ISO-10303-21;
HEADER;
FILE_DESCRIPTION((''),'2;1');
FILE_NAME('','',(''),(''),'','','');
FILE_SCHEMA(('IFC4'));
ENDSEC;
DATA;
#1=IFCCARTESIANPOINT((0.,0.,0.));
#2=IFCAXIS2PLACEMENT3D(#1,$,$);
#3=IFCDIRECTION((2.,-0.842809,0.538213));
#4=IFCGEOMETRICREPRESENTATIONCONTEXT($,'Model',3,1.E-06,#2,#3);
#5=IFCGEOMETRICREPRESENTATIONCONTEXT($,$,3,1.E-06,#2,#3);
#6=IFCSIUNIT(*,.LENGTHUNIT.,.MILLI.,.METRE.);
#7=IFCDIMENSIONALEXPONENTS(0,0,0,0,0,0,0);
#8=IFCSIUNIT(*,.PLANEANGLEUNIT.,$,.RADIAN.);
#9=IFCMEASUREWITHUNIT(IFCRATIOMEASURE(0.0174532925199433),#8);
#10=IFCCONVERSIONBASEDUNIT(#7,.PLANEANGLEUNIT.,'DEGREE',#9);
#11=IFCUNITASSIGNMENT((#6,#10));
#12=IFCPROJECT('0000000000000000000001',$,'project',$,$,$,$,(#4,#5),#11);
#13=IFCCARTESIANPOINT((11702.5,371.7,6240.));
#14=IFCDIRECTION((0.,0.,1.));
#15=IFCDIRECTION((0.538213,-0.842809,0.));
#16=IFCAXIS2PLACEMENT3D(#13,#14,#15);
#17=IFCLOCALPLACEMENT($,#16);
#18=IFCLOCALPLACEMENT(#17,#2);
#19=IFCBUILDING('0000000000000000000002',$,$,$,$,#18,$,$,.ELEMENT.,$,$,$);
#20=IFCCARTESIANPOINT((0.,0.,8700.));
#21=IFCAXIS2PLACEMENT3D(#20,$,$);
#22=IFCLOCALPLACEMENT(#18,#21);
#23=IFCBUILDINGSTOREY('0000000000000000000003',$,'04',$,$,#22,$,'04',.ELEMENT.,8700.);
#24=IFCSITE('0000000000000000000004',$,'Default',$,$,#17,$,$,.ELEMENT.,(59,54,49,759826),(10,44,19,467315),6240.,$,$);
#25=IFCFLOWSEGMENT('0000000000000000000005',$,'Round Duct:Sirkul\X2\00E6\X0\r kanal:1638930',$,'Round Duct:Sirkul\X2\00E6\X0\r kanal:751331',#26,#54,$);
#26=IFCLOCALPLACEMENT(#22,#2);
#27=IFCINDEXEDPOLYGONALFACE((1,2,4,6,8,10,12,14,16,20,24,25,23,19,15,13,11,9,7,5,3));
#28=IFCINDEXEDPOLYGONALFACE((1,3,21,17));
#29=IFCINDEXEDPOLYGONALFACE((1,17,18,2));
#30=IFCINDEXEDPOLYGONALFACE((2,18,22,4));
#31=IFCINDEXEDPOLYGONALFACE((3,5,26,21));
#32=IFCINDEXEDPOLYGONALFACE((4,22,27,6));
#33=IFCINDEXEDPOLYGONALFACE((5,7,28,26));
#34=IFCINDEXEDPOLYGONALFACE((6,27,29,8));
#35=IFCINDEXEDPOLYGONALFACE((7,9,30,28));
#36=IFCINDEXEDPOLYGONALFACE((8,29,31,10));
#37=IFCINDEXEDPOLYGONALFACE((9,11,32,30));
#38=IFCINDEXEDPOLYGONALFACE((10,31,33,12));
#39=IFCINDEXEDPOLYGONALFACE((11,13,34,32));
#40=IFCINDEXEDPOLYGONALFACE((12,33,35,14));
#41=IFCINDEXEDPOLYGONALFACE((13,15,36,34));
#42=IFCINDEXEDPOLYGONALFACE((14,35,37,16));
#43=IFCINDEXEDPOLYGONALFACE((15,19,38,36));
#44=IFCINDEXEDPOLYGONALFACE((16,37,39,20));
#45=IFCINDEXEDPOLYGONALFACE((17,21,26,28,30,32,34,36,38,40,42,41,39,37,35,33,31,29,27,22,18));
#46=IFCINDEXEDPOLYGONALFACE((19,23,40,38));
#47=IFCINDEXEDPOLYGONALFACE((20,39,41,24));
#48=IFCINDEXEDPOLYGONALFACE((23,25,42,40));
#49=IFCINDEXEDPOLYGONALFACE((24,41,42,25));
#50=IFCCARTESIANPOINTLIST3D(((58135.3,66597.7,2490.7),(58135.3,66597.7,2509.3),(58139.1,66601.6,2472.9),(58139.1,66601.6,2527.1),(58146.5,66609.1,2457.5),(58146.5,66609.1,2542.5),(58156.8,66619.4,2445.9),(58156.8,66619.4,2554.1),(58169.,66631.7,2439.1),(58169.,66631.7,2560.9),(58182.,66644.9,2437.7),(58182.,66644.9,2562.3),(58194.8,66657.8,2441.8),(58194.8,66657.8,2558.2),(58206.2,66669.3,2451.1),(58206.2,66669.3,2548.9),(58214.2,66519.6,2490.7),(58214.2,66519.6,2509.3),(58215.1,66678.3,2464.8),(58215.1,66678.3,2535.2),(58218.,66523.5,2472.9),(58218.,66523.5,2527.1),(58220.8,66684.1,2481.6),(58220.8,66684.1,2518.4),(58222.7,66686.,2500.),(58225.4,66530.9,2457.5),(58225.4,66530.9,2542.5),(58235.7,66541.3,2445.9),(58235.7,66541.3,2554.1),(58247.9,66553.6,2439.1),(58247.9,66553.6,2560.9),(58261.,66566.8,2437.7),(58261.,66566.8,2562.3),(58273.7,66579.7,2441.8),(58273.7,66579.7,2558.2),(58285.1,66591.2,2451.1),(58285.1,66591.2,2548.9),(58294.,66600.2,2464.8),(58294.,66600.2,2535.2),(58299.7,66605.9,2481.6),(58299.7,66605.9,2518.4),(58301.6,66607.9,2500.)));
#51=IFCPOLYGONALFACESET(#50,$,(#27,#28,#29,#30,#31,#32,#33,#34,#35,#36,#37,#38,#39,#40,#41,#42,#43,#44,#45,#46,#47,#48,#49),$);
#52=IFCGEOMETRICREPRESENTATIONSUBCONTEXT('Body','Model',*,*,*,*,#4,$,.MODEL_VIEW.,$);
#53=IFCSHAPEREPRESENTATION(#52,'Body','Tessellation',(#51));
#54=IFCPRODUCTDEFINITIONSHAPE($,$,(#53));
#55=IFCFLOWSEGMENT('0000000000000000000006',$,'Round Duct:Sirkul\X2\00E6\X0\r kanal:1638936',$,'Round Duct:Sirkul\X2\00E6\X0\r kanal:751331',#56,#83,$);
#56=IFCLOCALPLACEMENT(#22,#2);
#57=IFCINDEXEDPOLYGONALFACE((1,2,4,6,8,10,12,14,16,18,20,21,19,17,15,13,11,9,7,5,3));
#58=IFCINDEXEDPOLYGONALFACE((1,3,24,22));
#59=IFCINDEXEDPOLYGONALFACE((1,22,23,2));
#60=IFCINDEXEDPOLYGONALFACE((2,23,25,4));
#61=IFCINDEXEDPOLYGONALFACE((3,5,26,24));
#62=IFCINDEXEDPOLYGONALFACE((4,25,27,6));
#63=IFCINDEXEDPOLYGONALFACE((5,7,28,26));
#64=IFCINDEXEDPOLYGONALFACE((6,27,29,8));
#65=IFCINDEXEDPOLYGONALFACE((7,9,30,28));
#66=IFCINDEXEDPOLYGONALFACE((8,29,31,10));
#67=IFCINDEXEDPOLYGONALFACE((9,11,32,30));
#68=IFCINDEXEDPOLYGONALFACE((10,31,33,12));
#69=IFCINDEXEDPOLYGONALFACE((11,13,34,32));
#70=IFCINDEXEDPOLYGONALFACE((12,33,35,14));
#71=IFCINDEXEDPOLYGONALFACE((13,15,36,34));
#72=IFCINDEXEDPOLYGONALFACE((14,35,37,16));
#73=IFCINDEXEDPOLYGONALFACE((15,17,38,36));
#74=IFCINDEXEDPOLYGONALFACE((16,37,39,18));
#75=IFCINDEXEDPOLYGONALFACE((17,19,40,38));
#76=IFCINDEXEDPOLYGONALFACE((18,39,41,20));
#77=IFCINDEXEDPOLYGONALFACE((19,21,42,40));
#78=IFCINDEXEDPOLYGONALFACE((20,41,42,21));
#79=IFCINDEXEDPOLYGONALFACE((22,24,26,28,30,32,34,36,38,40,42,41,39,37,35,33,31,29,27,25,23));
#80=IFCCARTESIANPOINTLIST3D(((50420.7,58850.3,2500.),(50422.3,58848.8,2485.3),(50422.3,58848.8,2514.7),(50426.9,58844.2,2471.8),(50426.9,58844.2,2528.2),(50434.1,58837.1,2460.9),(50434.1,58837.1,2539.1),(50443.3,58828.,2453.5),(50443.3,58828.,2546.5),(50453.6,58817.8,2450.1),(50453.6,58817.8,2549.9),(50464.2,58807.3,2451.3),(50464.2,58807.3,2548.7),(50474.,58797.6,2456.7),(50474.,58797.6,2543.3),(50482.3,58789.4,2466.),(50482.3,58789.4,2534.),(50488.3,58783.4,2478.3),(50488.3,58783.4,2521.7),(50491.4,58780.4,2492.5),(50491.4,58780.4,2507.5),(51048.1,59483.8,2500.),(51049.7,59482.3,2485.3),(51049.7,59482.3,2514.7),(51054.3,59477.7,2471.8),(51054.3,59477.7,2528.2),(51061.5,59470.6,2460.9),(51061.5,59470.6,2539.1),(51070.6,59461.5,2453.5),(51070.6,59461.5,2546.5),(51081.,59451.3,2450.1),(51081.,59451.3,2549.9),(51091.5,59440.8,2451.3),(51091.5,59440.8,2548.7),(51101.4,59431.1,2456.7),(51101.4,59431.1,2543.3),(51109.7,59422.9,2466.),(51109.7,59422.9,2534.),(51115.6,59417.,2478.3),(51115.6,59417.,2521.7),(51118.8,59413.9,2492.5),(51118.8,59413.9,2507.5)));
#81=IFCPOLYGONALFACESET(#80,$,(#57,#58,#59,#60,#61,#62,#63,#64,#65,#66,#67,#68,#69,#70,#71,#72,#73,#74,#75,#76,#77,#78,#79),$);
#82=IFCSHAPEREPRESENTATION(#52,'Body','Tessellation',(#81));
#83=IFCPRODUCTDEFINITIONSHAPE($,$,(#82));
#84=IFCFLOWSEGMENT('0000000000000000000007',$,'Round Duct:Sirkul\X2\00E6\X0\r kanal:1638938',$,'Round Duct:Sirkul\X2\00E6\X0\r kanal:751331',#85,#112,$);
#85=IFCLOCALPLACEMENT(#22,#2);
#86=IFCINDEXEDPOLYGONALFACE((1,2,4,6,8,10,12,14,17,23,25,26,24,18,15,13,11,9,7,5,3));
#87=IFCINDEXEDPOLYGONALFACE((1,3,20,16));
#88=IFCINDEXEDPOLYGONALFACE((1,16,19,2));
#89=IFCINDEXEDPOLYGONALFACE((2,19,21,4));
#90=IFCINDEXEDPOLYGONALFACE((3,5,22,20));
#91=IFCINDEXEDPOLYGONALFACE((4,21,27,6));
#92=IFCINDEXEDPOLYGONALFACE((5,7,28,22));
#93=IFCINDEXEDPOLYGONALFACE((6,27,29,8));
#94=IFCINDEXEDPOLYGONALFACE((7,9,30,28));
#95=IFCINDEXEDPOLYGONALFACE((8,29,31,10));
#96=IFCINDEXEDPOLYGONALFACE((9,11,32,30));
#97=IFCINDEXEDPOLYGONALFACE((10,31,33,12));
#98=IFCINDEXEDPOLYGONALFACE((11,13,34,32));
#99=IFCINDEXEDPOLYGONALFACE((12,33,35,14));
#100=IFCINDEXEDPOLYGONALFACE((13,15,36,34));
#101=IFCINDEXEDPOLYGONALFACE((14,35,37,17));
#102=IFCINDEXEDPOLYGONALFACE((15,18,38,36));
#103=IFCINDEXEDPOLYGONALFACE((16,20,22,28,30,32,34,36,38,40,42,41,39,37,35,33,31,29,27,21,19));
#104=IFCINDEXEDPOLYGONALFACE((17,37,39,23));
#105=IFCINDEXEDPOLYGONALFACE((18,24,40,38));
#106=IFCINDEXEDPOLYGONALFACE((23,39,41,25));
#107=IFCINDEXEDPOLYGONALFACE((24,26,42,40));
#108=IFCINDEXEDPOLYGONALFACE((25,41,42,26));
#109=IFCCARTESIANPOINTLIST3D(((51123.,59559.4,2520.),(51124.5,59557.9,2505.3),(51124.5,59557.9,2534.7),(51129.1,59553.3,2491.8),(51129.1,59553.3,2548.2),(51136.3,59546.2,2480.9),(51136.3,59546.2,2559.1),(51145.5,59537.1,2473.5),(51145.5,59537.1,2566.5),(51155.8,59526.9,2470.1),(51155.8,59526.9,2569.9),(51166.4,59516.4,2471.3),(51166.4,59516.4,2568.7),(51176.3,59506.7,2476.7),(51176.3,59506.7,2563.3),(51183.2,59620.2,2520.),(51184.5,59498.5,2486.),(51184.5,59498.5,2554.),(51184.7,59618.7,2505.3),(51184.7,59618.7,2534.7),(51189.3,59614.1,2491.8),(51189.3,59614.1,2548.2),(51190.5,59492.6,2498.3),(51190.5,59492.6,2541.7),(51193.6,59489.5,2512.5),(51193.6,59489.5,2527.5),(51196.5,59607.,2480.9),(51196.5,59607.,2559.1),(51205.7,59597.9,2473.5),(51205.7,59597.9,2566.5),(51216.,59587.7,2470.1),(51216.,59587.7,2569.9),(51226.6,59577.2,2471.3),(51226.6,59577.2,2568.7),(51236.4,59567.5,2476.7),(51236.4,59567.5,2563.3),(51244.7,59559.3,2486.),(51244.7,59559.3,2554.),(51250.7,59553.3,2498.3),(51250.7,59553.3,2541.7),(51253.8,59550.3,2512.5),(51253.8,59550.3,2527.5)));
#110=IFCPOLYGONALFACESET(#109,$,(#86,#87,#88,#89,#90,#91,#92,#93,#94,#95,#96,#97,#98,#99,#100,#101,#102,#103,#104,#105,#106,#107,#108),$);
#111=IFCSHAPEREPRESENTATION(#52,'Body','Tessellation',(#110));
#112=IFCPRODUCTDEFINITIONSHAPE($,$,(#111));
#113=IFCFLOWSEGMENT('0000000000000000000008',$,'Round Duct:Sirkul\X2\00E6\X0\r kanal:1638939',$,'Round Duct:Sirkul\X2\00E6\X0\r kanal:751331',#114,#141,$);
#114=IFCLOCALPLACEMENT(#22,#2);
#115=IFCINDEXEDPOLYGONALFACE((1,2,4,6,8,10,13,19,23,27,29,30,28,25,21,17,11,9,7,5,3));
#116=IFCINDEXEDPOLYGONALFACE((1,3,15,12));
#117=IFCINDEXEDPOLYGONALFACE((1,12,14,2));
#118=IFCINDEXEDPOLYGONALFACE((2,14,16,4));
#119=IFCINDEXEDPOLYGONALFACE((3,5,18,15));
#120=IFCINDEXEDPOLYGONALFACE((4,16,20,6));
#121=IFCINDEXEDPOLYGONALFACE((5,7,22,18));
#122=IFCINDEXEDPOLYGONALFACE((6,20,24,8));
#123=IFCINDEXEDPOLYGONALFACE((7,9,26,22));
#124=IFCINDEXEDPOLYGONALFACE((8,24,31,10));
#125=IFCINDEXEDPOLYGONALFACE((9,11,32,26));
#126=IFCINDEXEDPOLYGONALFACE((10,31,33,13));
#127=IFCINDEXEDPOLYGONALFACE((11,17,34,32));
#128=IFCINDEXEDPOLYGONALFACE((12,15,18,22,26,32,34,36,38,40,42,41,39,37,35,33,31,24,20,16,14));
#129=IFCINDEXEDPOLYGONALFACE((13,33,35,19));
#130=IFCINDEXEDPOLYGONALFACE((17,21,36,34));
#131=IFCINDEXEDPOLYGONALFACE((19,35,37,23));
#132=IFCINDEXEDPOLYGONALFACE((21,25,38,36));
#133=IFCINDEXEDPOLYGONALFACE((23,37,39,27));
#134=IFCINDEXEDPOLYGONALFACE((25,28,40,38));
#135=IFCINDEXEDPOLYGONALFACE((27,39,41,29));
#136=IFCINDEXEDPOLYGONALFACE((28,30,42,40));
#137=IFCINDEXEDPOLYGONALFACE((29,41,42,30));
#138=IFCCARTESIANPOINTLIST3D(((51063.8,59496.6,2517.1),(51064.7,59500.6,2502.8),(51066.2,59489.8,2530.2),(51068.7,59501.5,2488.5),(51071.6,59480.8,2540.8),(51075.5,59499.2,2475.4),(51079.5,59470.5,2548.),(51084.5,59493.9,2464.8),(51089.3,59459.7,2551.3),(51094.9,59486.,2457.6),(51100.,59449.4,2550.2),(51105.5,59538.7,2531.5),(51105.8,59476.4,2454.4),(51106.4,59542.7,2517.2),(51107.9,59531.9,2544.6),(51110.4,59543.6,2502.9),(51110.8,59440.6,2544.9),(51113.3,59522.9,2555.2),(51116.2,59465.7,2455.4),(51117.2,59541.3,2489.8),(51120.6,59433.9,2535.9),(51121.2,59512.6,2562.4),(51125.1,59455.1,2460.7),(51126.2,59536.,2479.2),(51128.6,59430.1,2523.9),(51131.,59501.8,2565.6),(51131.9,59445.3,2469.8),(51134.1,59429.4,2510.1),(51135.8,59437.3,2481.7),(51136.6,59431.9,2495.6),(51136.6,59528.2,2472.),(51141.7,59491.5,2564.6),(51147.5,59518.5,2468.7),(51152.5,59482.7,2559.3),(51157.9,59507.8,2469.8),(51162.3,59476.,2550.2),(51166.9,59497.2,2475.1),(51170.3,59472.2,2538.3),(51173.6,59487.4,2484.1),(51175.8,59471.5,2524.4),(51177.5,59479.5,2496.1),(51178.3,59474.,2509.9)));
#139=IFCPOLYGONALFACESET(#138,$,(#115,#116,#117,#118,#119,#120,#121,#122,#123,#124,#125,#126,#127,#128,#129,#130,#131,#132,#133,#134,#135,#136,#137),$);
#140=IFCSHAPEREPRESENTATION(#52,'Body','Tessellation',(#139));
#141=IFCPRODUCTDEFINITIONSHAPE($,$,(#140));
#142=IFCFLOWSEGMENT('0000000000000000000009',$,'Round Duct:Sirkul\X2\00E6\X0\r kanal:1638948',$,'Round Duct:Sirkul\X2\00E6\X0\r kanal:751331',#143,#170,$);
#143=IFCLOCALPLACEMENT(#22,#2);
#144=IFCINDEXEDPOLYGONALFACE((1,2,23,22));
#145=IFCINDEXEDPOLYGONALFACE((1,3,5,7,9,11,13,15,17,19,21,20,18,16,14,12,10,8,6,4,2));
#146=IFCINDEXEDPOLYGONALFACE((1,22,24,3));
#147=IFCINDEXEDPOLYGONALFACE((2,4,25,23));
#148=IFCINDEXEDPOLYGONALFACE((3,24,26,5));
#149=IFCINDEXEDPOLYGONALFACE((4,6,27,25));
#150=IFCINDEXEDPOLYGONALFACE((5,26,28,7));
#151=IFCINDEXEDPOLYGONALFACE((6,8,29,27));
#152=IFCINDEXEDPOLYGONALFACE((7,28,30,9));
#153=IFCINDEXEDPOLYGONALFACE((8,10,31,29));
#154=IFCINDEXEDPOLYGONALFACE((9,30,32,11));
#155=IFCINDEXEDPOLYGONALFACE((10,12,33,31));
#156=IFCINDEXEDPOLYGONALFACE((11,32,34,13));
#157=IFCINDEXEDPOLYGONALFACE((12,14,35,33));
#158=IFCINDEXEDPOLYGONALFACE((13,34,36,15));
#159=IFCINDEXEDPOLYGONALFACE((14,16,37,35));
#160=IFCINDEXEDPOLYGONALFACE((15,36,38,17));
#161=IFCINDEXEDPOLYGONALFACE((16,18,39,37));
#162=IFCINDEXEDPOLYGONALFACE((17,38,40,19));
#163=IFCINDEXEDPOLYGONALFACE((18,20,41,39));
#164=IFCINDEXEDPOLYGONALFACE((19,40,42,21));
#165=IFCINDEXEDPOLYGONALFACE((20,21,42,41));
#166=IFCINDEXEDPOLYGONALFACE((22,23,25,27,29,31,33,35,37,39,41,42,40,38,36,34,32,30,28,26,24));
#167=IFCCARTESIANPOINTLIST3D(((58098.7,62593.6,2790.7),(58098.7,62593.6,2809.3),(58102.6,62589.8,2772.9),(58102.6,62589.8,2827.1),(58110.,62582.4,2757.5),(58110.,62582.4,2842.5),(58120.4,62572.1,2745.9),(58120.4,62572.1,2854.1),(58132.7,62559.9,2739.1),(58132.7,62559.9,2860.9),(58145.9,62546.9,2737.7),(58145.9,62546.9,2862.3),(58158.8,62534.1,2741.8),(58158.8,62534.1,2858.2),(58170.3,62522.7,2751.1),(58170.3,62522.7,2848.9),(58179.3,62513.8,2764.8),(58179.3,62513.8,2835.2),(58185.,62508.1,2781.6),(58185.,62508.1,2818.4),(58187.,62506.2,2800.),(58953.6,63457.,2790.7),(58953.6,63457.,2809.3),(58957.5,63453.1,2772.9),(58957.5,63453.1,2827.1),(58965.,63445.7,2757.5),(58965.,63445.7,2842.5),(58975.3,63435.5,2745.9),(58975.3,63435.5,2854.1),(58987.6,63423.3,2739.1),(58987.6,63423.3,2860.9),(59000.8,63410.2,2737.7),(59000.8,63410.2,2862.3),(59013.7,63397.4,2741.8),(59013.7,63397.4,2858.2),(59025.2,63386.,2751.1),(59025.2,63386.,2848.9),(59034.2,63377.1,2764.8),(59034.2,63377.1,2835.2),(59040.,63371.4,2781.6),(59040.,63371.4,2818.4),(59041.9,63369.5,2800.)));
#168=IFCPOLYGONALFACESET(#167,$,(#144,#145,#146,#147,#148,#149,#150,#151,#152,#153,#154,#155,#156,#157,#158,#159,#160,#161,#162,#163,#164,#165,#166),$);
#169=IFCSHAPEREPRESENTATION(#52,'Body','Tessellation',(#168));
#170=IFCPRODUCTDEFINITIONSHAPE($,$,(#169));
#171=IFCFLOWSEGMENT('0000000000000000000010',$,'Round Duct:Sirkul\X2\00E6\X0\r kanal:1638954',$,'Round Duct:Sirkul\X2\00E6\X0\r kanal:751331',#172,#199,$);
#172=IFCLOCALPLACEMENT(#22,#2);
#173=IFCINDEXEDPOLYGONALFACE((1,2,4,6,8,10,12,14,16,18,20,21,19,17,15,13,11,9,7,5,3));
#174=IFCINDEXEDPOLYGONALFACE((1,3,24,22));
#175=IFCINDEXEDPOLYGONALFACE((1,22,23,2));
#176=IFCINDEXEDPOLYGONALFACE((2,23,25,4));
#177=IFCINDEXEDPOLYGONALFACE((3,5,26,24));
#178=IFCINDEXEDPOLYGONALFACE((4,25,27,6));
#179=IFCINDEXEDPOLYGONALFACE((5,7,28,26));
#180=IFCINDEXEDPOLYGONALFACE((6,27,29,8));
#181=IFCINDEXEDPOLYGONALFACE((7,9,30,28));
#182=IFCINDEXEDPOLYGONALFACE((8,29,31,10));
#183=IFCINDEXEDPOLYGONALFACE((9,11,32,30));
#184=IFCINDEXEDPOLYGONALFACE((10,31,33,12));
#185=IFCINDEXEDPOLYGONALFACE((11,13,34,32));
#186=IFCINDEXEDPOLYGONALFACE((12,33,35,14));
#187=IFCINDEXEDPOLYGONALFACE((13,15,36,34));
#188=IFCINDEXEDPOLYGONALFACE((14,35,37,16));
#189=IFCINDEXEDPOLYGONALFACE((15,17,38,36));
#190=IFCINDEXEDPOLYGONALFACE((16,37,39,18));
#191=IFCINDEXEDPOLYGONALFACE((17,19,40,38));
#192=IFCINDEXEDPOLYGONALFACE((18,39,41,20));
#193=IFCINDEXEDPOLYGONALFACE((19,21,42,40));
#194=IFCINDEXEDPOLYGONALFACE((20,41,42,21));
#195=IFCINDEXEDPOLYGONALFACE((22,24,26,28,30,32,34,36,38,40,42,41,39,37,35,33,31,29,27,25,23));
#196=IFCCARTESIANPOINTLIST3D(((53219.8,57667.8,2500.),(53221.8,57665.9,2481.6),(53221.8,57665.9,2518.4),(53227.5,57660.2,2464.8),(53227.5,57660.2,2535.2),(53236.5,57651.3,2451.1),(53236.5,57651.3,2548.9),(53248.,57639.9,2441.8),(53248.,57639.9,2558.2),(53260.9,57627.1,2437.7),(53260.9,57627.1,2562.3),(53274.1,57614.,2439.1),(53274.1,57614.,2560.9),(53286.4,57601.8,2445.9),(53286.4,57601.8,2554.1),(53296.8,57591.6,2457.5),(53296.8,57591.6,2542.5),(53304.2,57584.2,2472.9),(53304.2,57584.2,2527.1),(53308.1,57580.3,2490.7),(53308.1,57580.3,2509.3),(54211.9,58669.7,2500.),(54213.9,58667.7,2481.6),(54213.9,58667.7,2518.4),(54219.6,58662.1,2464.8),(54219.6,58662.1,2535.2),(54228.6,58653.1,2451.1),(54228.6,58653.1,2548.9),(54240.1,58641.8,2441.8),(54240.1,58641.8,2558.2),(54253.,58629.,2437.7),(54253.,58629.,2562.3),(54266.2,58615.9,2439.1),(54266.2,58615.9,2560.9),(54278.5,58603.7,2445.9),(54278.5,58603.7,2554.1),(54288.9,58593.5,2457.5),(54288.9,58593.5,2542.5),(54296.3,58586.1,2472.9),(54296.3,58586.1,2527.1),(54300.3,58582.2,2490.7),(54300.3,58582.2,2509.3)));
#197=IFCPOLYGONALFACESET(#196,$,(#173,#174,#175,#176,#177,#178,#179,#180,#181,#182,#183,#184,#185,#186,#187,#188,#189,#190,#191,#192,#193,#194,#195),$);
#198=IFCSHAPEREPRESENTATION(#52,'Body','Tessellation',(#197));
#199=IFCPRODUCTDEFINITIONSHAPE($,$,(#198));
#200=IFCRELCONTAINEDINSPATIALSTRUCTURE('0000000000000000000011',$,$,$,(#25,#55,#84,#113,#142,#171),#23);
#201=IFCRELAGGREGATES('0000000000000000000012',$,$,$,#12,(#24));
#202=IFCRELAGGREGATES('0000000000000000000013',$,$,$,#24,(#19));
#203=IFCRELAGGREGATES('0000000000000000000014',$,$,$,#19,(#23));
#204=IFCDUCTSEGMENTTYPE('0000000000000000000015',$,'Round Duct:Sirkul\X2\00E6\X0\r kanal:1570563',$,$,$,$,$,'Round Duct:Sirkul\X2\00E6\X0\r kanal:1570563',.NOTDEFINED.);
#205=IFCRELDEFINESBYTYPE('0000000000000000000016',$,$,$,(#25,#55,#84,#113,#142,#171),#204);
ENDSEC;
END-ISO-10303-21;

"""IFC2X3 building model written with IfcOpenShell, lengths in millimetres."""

from ifc_helpers import new_model, entity, si_unit, converted_unit, direction, frame, frame_2d, origin, origin_2d_with_axis, place, context, subcontext, project, spatial, circle, extrude, type_object, element, save


model = new_model("IFC2X3")

# Units and contexts
model_context = context("Model", 3, precision=1e-06, world=origin(), true_north=direction((2.0, -0.842809, 0.538213)))
context_of_model = context(None, 3, precision=1e-06, world=origin(), true_north=direction((2.0, -0.842809, 0.538213)))
body_context = subcontext(model_context, "Body", "Model", "MODEL_VIEW")
ifc_project = project(units=[si_unit("LENGTHUNIT", "METRE", prefix="MILLI"), converted_unit("PLANEANGLEUNIT", "DEGREE", entity("IfcRatioMeasure", 0.0174532925199433), si_unit("PLANEANGLEUNIT", "RADIAN"), dimensions=[0, 0, 0, 0, 0, 0, 0])], contexts=[model_context, context_of_model])

# Site, building, storey
site_placement = place(None, frame((11702.5, 371.7, 6240.0), z_axis=(0.0, 0.0, 1.0), x_axis=(0.538213, -0.842809, 0.0)))
site = spatial("IfcSite", under=ifc_project, at=site_placement, Name="Default", CompositionType="ELEMENT", RefLatitude=(59, 54, 49, 759826), RefLongitude=(10, 44, 19, 467315), RefElevation=6240.0)
building_placement = place(site_placement, origin())
building = spatial("IfcBuilding", under=site, at=building_placement, CompositionType="ELEMENT")
storey_placement = place(building_placement, frame((0.0, 0.0, 8700.0)))
storey = spatial("IfcBuildingStorey", under=building, at=storey_placement, Name="04", LongName="04", CompositionType="ELEMENT", Elevation=8700.0)

# Flow segments
duct_segment_type = type_object("IfcDuctSegmentType", Name="Round Duct:Sirkulær kanal:1570563", ElementType="Round Duct:Sirkulær kanal:1570563", PredefinedType="NOTDEFINED")
flow_segment_1_placement = place(storey_placement, origin())
element("IfcFlowSegment", 1, at=flow_segment_1_placement, inside=storey, type_object=duct_segment_type, Name="Round Duct:Sirkulær kanal:1638930", ObjectType="Round Duct:Sirkulær kanal:751331", context=body_context, shape_type="SweptSolid", body=[
    extrude(circle(Radius=62.5, at=origin_2d_with_axis()), frame((58257.7, 66563.5, 2500.0), z_axis=(-0.710554, 0.703643, 0.0), x_axis=(0.703643, 0.710554, 0.0)), (0.0, 0.0, 1.0), 111.1),
])
flow_segment_2_placement = place(storey_placement, origin())
element("IfcFlowSegment", 2, at=flow_segment_2_placement, inside=storey, type_object=duct_segment_type, Name="Round Duct:Sirkulær kanal:1638936", ObjectType="Round Duct:Sirkulær kanal:751331", context=body_context, shape_type="SweptSolid", body=[
    extrude(circle(Radius=50.0, at=frame_2d((0.0, 0.0), x_axis=(1.0, 0.0))), frame((50456.3, 58815.1, 2500.0), z_axis=(0.703643, 0.710554, 0.0), x_axis=(-0.710554, 0.703643, 0.0)), (0.0, 0.0, 1.0), 891.6),
])
flow_segment_3_placement = place(storey_placement, origin())
element("IfcFlowSegment", 3, at=flow_segment_3_placement, inside=storey, type_object=duct_segment_type, Name="Round Duct:Sirkulær kanal:1638938", ObjectType="Round Duct:Sirkulær kanal:751331", context=body_context, shape_type="SweptSolid", body=[
    extrude(circle(Radius=50.0, at=frame_2d((0.0, 0.0), x_axis=(1.0, 0.0))), frame((51158.5, 59524.3, 2520.0), z_axis=(0.703643, 0.710554, 0.0), x_axis=(-0.710554, 0.703643, 0.0)), (0.0, 0.0, 1.0), 85.5),
])
flow_segment_4_placement = place(storey_placement, origin())
element("IfcFlowSegment", 4, at=flow_segment_4_placement, inside=storey, type_object=duct_segment_type, Name="Round Duct:Sirkulær kanal:1638939", ObjectType="Round Duct:Sirkulær kanal:751331", context=body_context, shape_type="SweptSolid", body=[
    extrude(circle(Radius=50.0, at=frame_2d((0.0, 0.0), x_axis=(1.0, 0.0))), frame((51100.2, 59465.4, 2502.8), z_axis=(0.683835, 0.690552, 0.2356), x_axis=(-0.710554, 0.703643, 0.0)), (0.0, 0.0, 1.0), 61.0),
])
flow_segment_5_placement = place(storey_placement, origin())
element("IfcFlowSegment", 5, at=flow_segment_5_placement, inside=storey, type_object=duct_segment_type, Name="Round Duct:Sirkulær kanal:1638948", ObjectType="Round Duct:Sirkulær kanal:751331", context=body_context, shape_type="SweptSolid", body=[
    extrude(circle(Radius=62.5, at=origin_2d_with_axis()), frame((58142.6, 62550.1, 2800.0), z_axis=(0.703643, 0.710554, 0.0), x_axis=(0.710554, -0.703643, 0.0)), (0.0, 0.0, 1.0), 1215.0),
])
flow_segment_6_placement = place(storey_placement, origin())
element("IfcFlowSegment", 6, at=flow_segment_6_placement, inside=storey, type_object=duct_segment_type, Name="Round Duct:Sirkulær kanal:1638954", ObjectType="Round Duct:Sirkulær kanal:751331", context=body_context, shape_type="SweptSolid", body=[
    extrude(circle(Radius=62.5, at=frame_2d((0.0, 0.0), x_axis=(1.0, 0.0))), frame((53264.2, 57623.8, 2500.0), z_axis=(0.703643, 0.710554, 0.0), x_axis=(-0.710554, 0.703643, 0.0)), (0.0, 0.0, 1.0), 1410.0),
])

save(model, "model.ifc")
